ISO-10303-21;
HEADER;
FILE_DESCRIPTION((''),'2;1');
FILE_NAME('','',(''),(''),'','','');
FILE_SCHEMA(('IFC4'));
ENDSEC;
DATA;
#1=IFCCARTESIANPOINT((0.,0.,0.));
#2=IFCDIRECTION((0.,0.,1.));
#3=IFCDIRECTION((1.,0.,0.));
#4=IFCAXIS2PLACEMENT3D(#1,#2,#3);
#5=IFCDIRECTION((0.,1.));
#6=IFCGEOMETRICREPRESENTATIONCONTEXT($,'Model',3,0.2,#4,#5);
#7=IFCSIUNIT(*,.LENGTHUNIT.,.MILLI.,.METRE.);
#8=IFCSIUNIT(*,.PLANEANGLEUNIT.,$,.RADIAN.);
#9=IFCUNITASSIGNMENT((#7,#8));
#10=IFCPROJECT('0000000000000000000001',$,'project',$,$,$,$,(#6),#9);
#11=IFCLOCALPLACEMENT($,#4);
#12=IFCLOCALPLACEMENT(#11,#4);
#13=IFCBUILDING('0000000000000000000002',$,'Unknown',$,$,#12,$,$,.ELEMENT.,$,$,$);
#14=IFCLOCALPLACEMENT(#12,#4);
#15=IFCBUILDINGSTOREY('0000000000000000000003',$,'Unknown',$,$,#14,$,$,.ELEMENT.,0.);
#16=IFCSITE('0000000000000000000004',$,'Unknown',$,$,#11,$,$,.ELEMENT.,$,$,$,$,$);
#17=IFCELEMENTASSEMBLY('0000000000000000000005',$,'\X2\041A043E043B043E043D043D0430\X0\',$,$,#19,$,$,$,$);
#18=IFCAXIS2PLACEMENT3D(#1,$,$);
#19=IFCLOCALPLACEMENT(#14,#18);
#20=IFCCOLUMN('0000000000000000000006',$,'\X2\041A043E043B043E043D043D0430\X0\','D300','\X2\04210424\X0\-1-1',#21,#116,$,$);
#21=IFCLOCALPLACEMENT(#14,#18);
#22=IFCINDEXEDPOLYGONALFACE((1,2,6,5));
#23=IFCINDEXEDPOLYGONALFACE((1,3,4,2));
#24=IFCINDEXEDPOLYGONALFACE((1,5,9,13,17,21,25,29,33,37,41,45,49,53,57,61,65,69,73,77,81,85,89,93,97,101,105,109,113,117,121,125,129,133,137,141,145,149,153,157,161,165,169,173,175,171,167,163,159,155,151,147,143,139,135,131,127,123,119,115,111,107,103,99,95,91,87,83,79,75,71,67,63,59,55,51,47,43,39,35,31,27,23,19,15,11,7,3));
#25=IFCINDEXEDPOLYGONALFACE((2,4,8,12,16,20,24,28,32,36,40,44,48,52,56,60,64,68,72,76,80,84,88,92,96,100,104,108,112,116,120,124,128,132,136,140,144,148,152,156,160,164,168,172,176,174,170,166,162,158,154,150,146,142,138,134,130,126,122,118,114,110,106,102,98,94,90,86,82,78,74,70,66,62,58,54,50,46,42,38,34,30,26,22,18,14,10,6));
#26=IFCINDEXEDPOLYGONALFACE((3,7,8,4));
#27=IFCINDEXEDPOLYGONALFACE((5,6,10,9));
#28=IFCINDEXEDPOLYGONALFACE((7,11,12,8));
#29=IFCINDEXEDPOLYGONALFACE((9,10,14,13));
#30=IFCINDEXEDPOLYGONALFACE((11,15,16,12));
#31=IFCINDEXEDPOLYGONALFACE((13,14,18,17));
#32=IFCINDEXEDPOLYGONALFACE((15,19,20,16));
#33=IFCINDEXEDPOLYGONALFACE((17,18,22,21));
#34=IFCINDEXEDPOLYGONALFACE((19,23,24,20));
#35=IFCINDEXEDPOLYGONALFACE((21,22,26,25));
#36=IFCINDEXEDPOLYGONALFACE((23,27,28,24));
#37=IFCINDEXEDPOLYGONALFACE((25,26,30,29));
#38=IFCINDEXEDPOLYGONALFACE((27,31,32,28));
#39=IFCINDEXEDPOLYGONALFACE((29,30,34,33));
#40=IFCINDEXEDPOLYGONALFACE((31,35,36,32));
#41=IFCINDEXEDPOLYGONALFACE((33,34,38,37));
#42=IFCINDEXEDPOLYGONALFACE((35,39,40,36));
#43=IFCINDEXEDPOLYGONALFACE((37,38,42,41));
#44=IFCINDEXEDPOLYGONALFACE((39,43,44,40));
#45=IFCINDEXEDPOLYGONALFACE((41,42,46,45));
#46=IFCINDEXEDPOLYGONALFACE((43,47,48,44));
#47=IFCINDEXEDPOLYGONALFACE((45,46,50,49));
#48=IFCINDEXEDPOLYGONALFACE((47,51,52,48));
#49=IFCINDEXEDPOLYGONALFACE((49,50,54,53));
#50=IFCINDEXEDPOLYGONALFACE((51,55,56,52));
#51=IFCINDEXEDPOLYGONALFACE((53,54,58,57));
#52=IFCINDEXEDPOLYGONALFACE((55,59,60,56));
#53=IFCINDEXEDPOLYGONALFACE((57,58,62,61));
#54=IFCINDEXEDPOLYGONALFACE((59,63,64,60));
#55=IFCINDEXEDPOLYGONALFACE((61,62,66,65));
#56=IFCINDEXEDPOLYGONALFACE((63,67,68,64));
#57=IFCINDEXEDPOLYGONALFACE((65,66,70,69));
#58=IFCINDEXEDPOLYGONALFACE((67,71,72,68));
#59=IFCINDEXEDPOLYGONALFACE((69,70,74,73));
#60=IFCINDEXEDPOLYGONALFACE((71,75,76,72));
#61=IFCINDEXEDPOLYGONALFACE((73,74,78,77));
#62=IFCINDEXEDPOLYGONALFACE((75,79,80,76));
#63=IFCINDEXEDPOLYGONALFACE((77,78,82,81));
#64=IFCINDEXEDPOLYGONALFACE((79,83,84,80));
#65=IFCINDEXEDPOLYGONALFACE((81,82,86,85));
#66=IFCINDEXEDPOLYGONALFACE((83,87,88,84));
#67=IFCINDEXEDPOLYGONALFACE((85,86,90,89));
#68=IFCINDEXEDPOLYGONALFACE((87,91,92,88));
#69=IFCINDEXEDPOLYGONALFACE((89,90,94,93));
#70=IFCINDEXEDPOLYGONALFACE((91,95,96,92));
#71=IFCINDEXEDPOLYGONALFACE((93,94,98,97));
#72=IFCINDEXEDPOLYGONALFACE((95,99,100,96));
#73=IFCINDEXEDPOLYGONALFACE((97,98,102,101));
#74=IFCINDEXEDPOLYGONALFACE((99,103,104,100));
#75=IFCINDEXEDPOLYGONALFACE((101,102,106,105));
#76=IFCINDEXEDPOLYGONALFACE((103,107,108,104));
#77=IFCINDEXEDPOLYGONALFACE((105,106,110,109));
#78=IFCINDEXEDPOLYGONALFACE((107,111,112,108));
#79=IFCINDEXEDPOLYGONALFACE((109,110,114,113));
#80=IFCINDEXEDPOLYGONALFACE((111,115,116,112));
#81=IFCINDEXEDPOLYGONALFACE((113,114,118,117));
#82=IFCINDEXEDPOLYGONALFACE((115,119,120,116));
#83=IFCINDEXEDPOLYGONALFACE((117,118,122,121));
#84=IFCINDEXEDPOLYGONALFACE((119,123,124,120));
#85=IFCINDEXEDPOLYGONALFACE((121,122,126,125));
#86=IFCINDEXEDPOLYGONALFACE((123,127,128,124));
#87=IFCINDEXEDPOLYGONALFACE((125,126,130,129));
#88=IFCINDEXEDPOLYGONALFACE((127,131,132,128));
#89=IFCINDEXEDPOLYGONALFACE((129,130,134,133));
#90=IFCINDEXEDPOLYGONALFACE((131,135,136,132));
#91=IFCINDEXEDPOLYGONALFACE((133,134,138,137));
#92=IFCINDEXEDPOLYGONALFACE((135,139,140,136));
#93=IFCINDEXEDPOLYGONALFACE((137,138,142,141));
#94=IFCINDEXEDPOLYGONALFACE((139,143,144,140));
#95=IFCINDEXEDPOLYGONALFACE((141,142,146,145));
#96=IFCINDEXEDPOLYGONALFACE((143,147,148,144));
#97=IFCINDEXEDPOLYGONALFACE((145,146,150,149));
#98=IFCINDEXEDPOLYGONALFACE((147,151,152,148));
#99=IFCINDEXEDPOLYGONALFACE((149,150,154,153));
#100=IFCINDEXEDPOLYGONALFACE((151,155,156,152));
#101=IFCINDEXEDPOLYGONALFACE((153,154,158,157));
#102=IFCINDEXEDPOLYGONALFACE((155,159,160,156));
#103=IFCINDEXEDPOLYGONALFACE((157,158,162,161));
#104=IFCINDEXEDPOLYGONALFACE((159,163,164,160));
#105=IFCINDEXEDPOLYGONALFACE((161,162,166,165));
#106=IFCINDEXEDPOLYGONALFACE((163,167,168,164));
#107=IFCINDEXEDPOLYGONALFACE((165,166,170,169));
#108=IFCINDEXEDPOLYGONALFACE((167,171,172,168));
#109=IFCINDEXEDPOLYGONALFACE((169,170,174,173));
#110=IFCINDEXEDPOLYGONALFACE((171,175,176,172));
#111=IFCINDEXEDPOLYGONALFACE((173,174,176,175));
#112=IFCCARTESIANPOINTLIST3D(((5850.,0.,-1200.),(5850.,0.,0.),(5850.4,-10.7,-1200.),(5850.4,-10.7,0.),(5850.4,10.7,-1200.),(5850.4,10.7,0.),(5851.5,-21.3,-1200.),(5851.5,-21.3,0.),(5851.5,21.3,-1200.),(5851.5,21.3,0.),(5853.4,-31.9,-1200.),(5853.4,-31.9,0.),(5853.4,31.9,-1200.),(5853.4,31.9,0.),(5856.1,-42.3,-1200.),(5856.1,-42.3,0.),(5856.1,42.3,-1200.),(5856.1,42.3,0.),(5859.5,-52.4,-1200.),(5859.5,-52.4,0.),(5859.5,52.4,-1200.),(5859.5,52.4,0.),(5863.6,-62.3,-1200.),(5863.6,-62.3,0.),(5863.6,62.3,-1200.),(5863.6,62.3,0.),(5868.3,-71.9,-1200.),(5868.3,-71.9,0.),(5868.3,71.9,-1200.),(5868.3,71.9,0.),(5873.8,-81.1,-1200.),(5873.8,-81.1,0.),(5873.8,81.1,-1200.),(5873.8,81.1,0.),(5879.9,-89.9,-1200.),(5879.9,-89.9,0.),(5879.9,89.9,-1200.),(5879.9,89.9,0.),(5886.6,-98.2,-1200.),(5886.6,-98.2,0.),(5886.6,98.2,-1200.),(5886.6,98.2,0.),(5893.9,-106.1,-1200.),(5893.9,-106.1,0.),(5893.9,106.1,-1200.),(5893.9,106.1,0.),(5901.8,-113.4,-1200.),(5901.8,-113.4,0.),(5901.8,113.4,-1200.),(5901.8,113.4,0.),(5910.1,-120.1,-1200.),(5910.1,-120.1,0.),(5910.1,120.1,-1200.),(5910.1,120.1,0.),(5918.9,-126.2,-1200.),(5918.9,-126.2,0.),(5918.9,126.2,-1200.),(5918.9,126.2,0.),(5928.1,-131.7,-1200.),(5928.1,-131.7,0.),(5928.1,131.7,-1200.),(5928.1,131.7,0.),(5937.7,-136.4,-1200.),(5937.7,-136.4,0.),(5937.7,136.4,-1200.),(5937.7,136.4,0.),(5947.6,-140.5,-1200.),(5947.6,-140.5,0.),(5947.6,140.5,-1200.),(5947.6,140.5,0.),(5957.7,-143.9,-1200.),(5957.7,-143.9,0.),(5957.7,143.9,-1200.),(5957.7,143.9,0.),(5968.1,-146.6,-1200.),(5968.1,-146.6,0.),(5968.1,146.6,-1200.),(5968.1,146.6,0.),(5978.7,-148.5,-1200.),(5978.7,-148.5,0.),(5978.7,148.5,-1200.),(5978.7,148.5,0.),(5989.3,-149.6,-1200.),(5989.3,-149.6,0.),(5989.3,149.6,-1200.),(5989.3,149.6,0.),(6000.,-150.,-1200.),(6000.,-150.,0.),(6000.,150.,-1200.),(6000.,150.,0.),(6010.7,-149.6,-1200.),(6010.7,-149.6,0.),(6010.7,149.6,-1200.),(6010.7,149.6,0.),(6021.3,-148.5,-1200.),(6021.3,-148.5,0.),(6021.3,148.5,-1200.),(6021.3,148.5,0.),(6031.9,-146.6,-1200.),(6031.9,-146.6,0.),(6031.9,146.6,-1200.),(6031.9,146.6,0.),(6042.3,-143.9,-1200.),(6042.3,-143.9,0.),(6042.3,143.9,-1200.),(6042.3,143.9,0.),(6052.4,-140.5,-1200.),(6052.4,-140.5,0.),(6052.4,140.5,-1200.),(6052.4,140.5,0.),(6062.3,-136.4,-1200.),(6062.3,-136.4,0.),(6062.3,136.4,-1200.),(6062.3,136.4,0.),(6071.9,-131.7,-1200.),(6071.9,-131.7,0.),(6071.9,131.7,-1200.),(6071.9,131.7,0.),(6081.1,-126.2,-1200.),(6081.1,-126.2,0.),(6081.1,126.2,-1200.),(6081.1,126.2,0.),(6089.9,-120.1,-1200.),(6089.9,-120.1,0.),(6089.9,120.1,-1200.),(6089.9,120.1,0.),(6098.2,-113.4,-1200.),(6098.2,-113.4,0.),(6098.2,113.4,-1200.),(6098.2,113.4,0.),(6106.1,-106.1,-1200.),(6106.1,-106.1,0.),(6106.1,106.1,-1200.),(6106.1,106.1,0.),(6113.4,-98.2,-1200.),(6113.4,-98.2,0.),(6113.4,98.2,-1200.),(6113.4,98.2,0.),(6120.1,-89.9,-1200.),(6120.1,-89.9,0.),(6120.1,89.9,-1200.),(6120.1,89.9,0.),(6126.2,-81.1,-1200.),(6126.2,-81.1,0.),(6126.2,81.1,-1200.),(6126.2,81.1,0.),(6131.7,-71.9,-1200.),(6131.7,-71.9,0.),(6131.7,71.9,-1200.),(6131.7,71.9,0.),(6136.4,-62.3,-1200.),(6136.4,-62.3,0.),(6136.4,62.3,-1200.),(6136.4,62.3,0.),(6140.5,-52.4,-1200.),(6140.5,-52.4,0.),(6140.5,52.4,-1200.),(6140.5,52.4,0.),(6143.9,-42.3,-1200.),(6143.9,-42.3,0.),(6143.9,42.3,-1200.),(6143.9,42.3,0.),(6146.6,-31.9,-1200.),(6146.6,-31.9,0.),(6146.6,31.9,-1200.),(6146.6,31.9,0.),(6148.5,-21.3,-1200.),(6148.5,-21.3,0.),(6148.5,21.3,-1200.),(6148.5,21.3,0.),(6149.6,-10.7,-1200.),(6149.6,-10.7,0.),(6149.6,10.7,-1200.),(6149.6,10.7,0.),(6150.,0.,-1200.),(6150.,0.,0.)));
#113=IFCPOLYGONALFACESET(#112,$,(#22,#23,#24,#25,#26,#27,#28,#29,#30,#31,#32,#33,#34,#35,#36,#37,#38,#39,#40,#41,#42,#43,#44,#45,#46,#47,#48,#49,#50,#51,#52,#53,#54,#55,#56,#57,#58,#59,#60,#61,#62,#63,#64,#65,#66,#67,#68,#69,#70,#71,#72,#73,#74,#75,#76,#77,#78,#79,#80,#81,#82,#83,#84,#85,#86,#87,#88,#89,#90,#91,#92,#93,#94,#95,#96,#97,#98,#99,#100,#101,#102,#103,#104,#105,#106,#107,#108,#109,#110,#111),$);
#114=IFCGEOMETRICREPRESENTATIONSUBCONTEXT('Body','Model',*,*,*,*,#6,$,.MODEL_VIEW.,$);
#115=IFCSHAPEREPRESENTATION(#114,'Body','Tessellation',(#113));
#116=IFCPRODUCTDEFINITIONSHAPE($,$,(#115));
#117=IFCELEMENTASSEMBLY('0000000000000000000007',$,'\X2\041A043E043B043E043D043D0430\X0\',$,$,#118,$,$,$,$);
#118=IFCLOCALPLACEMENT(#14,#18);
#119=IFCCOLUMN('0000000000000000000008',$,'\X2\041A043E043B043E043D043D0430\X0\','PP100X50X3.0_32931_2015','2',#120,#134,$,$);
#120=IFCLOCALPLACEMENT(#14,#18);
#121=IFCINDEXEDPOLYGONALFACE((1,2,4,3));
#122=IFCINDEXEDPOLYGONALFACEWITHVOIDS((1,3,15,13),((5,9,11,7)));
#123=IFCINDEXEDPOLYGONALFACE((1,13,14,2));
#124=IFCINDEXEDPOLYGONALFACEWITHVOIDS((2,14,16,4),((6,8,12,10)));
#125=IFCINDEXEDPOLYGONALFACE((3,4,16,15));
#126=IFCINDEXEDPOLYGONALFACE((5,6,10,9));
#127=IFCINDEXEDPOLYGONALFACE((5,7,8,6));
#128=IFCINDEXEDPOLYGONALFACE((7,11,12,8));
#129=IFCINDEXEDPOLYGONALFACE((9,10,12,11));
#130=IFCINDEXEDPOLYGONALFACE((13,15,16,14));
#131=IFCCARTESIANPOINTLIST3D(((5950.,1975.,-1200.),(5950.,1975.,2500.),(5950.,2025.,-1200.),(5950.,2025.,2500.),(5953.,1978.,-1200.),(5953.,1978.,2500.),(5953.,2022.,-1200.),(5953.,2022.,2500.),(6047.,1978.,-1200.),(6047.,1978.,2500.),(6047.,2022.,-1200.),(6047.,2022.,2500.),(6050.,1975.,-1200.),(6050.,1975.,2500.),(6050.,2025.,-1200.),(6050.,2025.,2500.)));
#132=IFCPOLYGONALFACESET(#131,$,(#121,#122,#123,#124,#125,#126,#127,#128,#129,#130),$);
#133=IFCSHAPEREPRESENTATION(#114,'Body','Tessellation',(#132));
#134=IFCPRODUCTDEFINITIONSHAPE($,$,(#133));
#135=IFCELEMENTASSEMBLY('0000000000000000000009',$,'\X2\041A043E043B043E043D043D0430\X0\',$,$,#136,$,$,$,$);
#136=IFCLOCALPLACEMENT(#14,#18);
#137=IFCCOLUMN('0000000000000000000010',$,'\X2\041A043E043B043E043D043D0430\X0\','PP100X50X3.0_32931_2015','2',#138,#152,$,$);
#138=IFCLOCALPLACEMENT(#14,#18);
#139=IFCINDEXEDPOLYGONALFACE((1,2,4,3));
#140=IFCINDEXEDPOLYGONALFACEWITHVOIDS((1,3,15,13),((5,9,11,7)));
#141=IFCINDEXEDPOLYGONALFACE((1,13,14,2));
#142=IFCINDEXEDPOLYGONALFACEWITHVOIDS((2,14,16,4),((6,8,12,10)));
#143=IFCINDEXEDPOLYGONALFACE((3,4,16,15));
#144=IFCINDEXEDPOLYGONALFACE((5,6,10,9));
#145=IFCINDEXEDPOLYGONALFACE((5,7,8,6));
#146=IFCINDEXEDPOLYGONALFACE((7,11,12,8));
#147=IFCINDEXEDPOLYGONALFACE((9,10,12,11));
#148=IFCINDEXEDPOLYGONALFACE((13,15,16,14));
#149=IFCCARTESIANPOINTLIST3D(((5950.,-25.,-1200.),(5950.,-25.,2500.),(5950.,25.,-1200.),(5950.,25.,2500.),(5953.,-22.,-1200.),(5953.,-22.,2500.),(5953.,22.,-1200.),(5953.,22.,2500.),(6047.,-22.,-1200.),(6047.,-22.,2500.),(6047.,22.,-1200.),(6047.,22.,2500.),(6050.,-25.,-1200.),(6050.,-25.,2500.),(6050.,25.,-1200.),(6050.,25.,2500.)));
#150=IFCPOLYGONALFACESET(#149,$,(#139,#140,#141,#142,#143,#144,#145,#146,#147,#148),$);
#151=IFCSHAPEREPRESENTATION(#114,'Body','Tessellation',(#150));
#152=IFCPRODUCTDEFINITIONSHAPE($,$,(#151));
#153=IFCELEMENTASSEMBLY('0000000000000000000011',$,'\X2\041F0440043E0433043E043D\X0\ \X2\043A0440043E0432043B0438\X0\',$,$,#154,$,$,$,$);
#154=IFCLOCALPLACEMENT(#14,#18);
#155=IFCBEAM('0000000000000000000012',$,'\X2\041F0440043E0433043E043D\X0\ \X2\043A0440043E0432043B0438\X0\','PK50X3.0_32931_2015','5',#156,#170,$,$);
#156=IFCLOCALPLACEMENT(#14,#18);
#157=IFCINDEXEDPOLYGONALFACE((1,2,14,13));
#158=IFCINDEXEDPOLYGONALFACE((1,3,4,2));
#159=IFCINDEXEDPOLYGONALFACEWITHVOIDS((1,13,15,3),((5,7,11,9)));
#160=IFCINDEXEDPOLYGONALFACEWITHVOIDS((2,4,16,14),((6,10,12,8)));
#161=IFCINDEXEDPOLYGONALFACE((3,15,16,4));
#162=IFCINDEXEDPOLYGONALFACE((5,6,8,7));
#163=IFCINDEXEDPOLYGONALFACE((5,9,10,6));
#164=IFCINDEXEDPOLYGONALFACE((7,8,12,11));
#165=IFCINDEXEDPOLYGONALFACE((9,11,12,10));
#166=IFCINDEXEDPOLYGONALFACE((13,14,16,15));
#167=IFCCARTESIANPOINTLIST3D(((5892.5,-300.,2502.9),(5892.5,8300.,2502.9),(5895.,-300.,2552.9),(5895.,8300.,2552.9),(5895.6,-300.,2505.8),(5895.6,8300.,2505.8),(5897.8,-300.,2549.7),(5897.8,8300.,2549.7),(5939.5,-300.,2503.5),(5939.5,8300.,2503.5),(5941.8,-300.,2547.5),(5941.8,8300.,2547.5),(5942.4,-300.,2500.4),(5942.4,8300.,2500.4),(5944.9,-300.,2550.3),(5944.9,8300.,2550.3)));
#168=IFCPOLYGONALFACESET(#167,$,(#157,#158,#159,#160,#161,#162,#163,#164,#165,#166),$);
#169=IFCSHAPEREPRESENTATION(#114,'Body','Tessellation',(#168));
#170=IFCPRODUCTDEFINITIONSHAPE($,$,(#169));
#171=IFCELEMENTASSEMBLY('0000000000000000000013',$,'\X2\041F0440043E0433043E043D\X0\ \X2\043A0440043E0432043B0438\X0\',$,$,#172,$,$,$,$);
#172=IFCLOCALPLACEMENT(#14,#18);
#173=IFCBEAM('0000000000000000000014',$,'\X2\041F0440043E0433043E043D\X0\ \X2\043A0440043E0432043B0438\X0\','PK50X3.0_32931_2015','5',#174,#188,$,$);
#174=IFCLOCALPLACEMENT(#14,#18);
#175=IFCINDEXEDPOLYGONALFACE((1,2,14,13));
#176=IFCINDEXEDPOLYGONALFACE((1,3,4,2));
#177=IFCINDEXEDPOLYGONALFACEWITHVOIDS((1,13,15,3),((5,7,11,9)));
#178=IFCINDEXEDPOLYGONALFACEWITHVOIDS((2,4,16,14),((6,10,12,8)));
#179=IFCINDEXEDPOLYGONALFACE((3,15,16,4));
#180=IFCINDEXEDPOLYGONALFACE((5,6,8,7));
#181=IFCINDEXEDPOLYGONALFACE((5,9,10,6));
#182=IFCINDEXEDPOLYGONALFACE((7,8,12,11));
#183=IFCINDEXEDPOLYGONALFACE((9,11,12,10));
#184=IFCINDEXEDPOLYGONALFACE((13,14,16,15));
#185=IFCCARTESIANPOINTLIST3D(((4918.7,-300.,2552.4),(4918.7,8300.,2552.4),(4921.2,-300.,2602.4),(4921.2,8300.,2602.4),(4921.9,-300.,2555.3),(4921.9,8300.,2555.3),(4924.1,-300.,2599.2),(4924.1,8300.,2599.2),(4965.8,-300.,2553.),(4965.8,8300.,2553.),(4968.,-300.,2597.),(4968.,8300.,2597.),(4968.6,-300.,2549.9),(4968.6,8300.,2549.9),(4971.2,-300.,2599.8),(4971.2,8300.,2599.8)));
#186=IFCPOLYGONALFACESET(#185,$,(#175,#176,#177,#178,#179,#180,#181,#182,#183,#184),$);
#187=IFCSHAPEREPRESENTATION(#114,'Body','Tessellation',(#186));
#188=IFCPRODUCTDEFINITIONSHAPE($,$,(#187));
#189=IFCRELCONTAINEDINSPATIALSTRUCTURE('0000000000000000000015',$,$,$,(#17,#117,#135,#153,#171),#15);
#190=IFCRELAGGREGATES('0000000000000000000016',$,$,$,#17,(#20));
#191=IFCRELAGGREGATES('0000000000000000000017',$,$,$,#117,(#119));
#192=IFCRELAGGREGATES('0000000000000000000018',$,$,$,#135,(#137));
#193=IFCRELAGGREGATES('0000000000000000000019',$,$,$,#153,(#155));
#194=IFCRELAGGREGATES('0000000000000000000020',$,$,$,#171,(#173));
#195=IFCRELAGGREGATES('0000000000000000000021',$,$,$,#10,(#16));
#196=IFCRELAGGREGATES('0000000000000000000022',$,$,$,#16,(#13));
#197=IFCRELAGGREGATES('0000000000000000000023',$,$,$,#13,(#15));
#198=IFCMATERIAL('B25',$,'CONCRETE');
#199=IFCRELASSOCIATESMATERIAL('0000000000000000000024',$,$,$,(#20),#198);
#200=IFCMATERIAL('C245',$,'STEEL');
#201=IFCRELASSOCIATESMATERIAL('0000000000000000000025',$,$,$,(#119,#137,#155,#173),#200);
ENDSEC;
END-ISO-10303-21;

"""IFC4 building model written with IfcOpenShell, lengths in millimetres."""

from ifc_helpers import new_model, si_unit, direction, frame, origin_with_axes, place, context, subcontext, project, spatial, line, indexed_curve, outline, extrude, material, element, aggregate, save


model = new_model("IFC4")

# Units and contexts
model_context = context("Model", 3, precision=0.2, world=origin_with_axes(), true_north=direction((0.0, 1.0)))
body_context = subcontext(model_context, "Body", "Model", "MODEL_VIEW")
ifc_project = project(units=[si_unit("LENGTHUNIT", "METRE", prefix="MILLI"), si_unit("PLANEANGLEUNIT", "RADIAN")], contexts=[model_context])

# Site, building, storey
site_placement = place(None, origin_with_axes())
site = spatial("IfcSite", under=ifc_project, at=site_placement, Name="Unknown", CompositionType="ELEMENT")
building_placement = place(site_placement, origin_with_axes())
building = spatial("IfcBuilding", under=site, at=building_placement, Name="Unknown", CompositionType="ELEMENT")
storey_placement = place(building_placement, origin_with_axes())
storey = spatial("IfcBuildingStorey", under=building, at=storey_placement, Name="Unknown", CompositionType="ELEMENT", Elevation=0.0)

# Element assemblies, columns
ifc_material_1 = material(Name="B25", Category="CONCRETE")
assembly_1_placement = place(storey_placement, frame((6000.0, 0.0, -1200.0), z_axis=(-1.0, 0.0, 0.0), x_axis=(0.0, 0.0, 1.0)))
assembly_1 = element("IfcElementAssembly", 1, at=assembly_1_placement, inside=storey, Name="Колонна")
column_1_placement = place(assembly_1_placement, origin_with_axes())
column_1 = element("IfcColumn", 2, at=column_1_placement, material=ifc_material_1, Name="Колонна", Description="D300", ObjectType="СФ-1-1", context=body_context, shape_type="SolidModel", body=[
    extrude(outline(indexed_curve([(150.0, 0.0), (149.6, 10.7), (148.5, 21.3), (146.6, 31.9), (143.9, 42.3), (140.5, 52.4), (136.4, 62.3), (131.7, 71.9), (126.2, 81.1), (120.1, 89.9), (113.4, 98.2), (106.1, 106.1), (98.2, 113.4), (89.9, 120.1), (81.1, 126.2), (71.9, 131.7), (62.3, 136.4), (52.4, 140.5), (42.3, 143.9), (31.9, 146.6), (21.3, 148.5), (10.7, 149.6), (0.0, 150.0), (-10.7, 149.6), (-21.3, 148.5), (-31.9, 146.6), (-42.3, 143.9), (-52.4, 140.5), (-62.3, 136.4), (-71.9, 131.7), (-81.1, 126.2), (-89.9, 120.1), (-98.2, 113.4), (-106.1, 106.1), (-113.4, 98.2), (-120.1, 89.9), (-126.2, 81.1), (-131.7, 71.9), (-136.4, 62.3), (-140.5, 52.4), (-143.9, 42.3), (-146.6, 31.9), (-148.5, 21.3), (-149.6, 10.7), (-150.0, 0.0), (-149.6, -10.7), (-148.5, -21.3), (-146.6, -31.9), (-143.9, -42.3), (-140.5, -52.4), (-136.4, -62.3), (-131.7, -71.9), (-126.2, -81.1), (-120.1, -89.9), (-113.4, -98.2), (-106.1, -106.1), (-98.2, -113.4), (-89.9, -120.1), (-81.1, -126.2), (-71.9, -131.7), (-62.3, -136.4), (-52.4, -140.5), (-42.3, -143.9), (-31.9, -146.6), (-21.3, -148.5), (-10.7, -149.6), (0.0, -150.0), (10.7, -149.6), (21.3, -148.5), (31.9, -146.6), (42.3, -143.9), (52.4, -140.5), (62.3, -136.4), (71.9, -131.7), (81.1, -126.2), (89.9, -120.1), (98.2, -113.4), (106.1, -106.1), (113.4, -98.2), (120.1, -89.9), (126.2, -81.1), (131.7, -71.9), (136.4, -62.3), (140.5, -52.4), (143.9, -42.3), (146.6, -31.9), (148.5, -21.3), (149.6, -10.7)], segments=[line(1, 2, 3, 4, 5, 6, 7, 8, 9, 10, 11, 12, 13, 14, 15, 16, 17, 18, 19, 20, 21, 22, 23, 24, 25, 26, 27, 28, 29, 30, 31, 32, 33, 34, 35, 36, 37, 38, 39, 40, 41, 42, 43, 44, 45, 46, 47, 48, 49, 50, 51, 52, 53, 54, 55, 56, 57, 58, 59, 60, 61, 62, 63, 64, 65, 66, 67, 68, 69, 70, 71, 72, 73, 74, 75, 76, 77, 78, 79, 80, 81, 82, 83, 84, 85, 86, 87, 88, 1)])), frame((0.0, 0.0, 0.0), z_axis=(-1.0, 0.0, 0.0), x_axis=(0.0, 0.0, 1.0)), (0.0, 0.0, -1.0), 1200.0),
])
aggregate(assembly_1, [column_1])
assembly_2_placement = place(storey_placement, frame((6000.0, 2000.0, -1200.0), z_axis=(0.0, -1.0, 0.0), x_axis=(0.0, 0.0, 1.0)))
assembly_2 = element("IfcElementAssembly", 3, at=assembly_2_placement, inside=storey, Name="Колонна")
ifc_material_2 = material(Name="C245", Category="STEEL")
column_2_placement = place(assembly_2_placement, origin_with_axes())
column_2 = element("IfcColumn", 4, at=column_2_placement, material=ifc_material_2, Name="Колонна", Description="PP100X50X3.0_32931_2015", ObjectType="2", context=body_context, shape_type="SolidModel", body=[
    extrude(outline(indexed_curve([(-25.0, -50.0), (25.0, -50.0), (25.0, 50.0), (-25.0, 50.0)], segments=[line(1, 2, 3, 4, 1)]), holes=[indexed_curve([(-22.0, -47.0), (-22.0, 47.0), (22.0, 47.0), (22.0, -47.0)], segments=[line(1, 2, 3, 4, 1)])]), frame((0.0, 0.0, 0.0), z_axis=(-1.0, 0.0, 0.0), x_axis=(0.0, 0.0, 1.0)), (0.0, 0.0, -1.0), 3700.0),
])
aggregate(assembly_2, [column_2])
assembly_3_placement = place(storey_placement, frame((6000.0, 0.0, -1200.0), z_axis=(0.0, -1.0, 0.0), x_axis=(0.0, 0.0, 1.0)))
assembly_3 = element("IfcElementAssembly", 5, at=assembly_3_placement, inside=storey, Name="Колонна")
column_3_placement = place(assembly_3_placement, origin_with_axes())
column_3 = element("IfcColumn", 6, at=column_3_placement, material=ifc_material_2, Name="Колонна", Description="PP100X50X3.0_32931_2015", ObjectType="2", context=body_context, shape_type="SolidModel", body=[
    extrude(outline(indexed_curve([(-25.0, -50.0), (25.0, -50.0), (25.0, 50.0), (-25.0, 50.0)], segments=[line(1, 2, 3, 4, 1)]), holes=[indexed_curve([(-22.0, -47.0), (-22.0, 47.0), (22.0, 47.0), (22.0, -47.0)], segments=[line(1, 2, 3, 4, 1)])]), frame((0.0, 0.0, 0.0), z_axis=(-1.0, 0.0, 0.0), x_axis=(0.0, 0.0, 1.0)), (0.0, 0.0, -1.0), 3700.0),
])
aggregate(assembly_3, [column_3])

# Element assemblies, beams
assembly_4_placement = place(storey_placement, frame((5918.7, -300.0, 2526.6), z_axis=(0.99871, 0.0, -0.050782), x_axis=(0.0, 1.0, 0.0)))
assembly_4 = element("IfcElementAssembly", 7, at=assembly_4_placement, inside=storey, Name="Прогон кровли")
beam_1_placement = place(assembly_4_placement, origin_with_axes())
beam_1 = element("IfcBeam", 8, at=beam_1_placement, material=ifc_material_2, Name="Прогон кровли", Description="PK50X3.0_32931_2015", ObjectType="5", context=body_context, shape_type="SolidModel", body=[
    extrude(outline(indexed_curve([(-25.0, -25.0), (25.0, -25.0), (25.0, 25.0), (-25.0, 25.0)], segments=[line(1, 2, 3, 4, 1)]), holes=[indexed_curve([(-22.0, -22.0), (-22.0, 22.0), (22.0, 22.0), (22.0, -22.0)], segments=[line(1, 2, 3, 4, 1)])]), frame((0.0, 0.0, 0.0), z_axis=(-1.0, 0.0, 0.0), x_axis=(0.0, 0.0, 1.0)), (0.0, 0.0, -1.0), 8600.0),
])
aggregate(assembly_4, [beam_1])
assembly_5_placement = place(storey_placement, frame((4944.9, -300.0, 2576.1), z_axis=(0.99871, 0.0, -0.050782), x_axis=(0.0, 1.0, 0.0)))
assembly_5 = element("IfcElementAssembly", 9, at=assembly_5_placement, inside=storey, Name="Прогон кровли")
beam_2_placement = place(assembly_5_placement, origin_with_axes())
beam_2 = element("IfcBeam", 10, at=beam_2_placement, material=ifc_material_2, Name="Прогон кровли", Description="PK50X3.0_32931_2015", ObjectType="5", context=body_context, shape_type="SolidModel", body=[
    extrude(outline(indexed_curve([(-25.0, -25.0), (25.0, -25.0), (25.0, 25.0), (-25.0, 25.0)], segments=[line(1, 2, 3, 4, 1)]), holes=[indexed_curve([(-22.0, -22.0), (-22.0, 22.0), (22.0, 22.0), (22.0, -22.0)], segments=[line(1, 2, 3, 4, 1)])]), frame((0.0, 0.0, 0.0), z_axis=(-1.0, 0.0, 0.0), x_axis=(0.0, 0.0, 1.0)), (0.0, 0.0, -1.0), 8600.0),
])
aggregate(assembly_5, [beam_2])

save(model, "model.ifc")
